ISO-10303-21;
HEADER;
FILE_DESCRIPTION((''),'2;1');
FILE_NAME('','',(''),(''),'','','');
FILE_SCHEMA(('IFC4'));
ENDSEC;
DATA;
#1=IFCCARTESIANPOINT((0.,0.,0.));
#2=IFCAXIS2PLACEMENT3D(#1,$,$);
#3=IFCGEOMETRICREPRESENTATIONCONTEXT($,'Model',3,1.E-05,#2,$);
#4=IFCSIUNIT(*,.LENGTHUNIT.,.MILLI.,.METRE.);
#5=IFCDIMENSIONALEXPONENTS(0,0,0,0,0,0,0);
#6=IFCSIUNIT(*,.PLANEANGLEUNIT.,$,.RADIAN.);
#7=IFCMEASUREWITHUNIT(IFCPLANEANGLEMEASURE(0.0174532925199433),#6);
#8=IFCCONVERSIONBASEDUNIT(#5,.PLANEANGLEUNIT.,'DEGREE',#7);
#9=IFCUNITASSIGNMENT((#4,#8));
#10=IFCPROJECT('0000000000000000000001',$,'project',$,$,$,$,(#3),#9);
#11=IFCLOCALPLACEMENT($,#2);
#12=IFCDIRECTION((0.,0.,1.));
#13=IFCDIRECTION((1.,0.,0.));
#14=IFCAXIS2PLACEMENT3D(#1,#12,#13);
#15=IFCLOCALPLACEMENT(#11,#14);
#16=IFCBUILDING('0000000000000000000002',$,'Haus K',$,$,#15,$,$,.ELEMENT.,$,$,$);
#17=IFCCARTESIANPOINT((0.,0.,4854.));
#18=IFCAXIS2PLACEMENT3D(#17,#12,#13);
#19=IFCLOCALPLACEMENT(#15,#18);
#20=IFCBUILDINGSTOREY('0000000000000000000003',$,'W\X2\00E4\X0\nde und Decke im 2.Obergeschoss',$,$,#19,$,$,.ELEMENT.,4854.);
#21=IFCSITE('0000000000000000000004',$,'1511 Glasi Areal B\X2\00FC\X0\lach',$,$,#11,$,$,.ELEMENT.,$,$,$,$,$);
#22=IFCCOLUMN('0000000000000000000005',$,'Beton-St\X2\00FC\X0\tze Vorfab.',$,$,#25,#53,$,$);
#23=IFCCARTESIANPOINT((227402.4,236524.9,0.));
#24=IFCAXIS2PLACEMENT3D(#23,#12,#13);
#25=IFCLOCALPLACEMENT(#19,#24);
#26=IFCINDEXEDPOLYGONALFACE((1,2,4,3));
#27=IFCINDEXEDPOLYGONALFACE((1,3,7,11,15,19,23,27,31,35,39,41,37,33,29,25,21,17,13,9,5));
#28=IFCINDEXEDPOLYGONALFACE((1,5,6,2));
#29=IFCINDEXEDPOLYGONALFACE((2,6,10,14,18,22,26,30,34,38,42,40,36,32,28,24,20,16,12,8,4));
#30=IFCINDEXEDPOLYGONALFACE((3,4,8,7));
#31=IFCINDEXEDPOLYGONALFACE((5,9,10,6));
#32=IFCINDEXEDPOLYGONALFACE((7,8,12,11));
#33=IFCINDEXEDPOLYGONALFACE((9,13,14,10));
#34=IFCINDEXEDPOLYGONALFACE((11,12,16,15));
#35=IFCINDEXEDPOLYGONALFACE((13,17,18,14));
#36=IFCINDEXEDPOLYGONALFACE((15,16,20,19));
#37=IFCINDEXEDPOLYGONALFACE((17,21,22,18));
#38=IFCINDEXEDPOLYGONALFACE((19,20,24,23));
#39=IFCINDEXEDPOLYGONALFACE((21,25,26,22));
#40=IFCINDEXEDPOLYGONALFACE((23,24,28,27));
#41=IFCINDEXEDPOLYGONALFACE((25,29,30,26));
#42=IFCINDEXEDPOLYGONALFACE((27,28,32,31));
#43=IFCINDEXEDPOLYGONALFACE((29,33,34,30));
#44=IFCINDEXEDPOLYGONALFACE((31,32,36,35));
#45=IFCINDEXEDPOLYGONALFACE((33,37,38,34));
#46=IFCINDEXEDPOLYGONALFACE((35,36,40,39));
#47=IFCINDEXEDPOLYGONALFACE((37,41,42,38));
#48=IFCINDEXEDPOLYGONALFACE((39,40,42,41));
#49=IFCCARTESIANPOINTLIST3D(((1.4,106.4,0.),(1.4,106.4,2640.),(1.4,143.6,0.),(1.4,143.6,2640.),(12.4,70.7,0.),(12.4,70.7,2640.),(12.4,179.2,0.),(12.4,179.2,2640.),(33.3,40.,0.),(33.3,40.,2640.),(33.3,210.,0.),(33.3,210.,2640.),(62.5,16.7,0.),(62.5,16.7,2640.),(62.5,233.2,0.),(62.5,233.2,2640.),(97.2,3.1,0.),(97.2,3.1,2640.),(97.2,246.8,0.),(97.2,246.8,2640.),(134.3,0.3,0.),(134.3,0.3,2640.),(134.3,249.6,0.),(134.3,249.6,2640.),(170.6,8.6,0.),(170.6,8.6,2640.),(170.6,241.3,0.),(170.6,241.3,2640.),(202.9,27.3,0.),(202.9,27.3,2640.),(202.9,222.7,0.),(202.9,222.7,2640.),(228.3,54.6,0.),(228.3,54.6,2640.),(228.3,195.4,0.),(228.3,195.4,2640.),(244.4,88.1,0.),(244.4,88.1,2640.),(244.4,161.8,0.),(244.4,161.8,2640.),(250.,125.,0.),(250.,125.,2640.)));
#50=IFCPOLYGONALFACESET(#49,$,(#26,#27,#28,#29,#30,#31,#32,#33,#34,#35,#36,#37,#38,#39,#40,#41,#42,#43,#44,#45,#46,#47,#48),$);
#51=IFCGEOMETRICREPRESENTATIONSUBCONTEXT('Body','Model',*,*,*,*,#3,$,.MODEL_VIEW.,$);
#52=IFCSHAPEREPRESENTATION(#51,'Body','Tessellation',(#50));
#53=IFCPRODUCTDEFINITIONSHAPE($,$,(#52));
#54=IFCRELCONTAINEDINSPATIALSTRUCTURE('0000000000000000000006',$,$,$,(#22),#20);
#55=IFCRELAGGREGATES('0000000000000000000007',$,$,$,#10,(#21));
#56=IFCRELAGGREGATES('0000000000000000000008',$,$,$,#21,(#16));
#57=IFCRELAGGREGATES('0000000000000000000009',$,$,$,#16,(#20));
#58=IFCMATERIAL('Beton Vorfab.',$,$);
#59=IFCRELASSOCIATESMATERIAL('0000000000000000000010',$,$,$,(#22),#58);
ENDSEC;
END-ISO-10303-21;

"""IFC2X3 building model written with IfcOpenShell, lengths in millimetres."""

from ifc_helpers import new_model, entity, si_unit, converted_unit, frame, frame_2d, origin, origin_with_axes, place, context, subcontext, project, spatial, circle, extrude, material, element, save


model = new_model("IFC2X3")

# Units and contexts
model_context = context("Model", 3, precision=1e-05, world=origin())
body_context = subcontext(model_context, "Body", "Model", "MODEL_VIEW")
ifc_project = project(units=[si_unit("LENGTHUNIT", "METRE", prefix="MILLI"), converted_unit("PLANEANGLEUNIT", "DEGREE", entity("IfcPlaneAngleMeasure", 0.0174532925199433), si_unit("PLANEANGLEUNIT", "RADIAN"), dimensions=[0, 0, 0, 0, 0, 0, 0])], contexts=[model_context])

# Site, building, storey
site_placement = place(None, origin())
site = spatial("IfcSite", under=ifc_project, at=site_placement, Name="1511 Glasi Areal Bülach", CompositionType="ELEMENT")
building_placement = place(site_placement, origin_with_axes())
building = spatial("IfcBuilding", under=site, at=building_placement, Name="Haus K", CompositionType="ELEMENT")
storey_placement = place(building_placement, frame((0.0, 0.0, 4854.0), z_axis=(0.0, 0.0, 1.0), x_axis=(1.0, 0.0, 0.0)))
storey = spatial("IfcBuildingStorey", under=building, at=storey_placement, Name="Wände und Decke im 2.Obergeschoss", CompositionType="ELEMENT", Elevation=4854.0)

# Column
ifc_material_1 = material(Name="Beton Vorfab.")
column_placement = place(storey_placement, frame((227402.4, 236524.9, 0.0), z_axis=(0.0, 0.0, 1.0), x_axis=(1.0, 0.0, 0.0)))
element("IfcColumn", 1, at=column_placement, inside=storey, material=ifc_material_1, Name="Beton-Stütze Vorfab.", context=body_context, shape_type="SweptSolid", body=[
    extrude(circle(Radius=125.0, at=frame_2d((125.0, 125.0), x_axis=(1.0, 0.0))), origin_with_axes(), (0.0, 0.0, 1.0), 2640.0),
])

save(model, "model.ifc")
